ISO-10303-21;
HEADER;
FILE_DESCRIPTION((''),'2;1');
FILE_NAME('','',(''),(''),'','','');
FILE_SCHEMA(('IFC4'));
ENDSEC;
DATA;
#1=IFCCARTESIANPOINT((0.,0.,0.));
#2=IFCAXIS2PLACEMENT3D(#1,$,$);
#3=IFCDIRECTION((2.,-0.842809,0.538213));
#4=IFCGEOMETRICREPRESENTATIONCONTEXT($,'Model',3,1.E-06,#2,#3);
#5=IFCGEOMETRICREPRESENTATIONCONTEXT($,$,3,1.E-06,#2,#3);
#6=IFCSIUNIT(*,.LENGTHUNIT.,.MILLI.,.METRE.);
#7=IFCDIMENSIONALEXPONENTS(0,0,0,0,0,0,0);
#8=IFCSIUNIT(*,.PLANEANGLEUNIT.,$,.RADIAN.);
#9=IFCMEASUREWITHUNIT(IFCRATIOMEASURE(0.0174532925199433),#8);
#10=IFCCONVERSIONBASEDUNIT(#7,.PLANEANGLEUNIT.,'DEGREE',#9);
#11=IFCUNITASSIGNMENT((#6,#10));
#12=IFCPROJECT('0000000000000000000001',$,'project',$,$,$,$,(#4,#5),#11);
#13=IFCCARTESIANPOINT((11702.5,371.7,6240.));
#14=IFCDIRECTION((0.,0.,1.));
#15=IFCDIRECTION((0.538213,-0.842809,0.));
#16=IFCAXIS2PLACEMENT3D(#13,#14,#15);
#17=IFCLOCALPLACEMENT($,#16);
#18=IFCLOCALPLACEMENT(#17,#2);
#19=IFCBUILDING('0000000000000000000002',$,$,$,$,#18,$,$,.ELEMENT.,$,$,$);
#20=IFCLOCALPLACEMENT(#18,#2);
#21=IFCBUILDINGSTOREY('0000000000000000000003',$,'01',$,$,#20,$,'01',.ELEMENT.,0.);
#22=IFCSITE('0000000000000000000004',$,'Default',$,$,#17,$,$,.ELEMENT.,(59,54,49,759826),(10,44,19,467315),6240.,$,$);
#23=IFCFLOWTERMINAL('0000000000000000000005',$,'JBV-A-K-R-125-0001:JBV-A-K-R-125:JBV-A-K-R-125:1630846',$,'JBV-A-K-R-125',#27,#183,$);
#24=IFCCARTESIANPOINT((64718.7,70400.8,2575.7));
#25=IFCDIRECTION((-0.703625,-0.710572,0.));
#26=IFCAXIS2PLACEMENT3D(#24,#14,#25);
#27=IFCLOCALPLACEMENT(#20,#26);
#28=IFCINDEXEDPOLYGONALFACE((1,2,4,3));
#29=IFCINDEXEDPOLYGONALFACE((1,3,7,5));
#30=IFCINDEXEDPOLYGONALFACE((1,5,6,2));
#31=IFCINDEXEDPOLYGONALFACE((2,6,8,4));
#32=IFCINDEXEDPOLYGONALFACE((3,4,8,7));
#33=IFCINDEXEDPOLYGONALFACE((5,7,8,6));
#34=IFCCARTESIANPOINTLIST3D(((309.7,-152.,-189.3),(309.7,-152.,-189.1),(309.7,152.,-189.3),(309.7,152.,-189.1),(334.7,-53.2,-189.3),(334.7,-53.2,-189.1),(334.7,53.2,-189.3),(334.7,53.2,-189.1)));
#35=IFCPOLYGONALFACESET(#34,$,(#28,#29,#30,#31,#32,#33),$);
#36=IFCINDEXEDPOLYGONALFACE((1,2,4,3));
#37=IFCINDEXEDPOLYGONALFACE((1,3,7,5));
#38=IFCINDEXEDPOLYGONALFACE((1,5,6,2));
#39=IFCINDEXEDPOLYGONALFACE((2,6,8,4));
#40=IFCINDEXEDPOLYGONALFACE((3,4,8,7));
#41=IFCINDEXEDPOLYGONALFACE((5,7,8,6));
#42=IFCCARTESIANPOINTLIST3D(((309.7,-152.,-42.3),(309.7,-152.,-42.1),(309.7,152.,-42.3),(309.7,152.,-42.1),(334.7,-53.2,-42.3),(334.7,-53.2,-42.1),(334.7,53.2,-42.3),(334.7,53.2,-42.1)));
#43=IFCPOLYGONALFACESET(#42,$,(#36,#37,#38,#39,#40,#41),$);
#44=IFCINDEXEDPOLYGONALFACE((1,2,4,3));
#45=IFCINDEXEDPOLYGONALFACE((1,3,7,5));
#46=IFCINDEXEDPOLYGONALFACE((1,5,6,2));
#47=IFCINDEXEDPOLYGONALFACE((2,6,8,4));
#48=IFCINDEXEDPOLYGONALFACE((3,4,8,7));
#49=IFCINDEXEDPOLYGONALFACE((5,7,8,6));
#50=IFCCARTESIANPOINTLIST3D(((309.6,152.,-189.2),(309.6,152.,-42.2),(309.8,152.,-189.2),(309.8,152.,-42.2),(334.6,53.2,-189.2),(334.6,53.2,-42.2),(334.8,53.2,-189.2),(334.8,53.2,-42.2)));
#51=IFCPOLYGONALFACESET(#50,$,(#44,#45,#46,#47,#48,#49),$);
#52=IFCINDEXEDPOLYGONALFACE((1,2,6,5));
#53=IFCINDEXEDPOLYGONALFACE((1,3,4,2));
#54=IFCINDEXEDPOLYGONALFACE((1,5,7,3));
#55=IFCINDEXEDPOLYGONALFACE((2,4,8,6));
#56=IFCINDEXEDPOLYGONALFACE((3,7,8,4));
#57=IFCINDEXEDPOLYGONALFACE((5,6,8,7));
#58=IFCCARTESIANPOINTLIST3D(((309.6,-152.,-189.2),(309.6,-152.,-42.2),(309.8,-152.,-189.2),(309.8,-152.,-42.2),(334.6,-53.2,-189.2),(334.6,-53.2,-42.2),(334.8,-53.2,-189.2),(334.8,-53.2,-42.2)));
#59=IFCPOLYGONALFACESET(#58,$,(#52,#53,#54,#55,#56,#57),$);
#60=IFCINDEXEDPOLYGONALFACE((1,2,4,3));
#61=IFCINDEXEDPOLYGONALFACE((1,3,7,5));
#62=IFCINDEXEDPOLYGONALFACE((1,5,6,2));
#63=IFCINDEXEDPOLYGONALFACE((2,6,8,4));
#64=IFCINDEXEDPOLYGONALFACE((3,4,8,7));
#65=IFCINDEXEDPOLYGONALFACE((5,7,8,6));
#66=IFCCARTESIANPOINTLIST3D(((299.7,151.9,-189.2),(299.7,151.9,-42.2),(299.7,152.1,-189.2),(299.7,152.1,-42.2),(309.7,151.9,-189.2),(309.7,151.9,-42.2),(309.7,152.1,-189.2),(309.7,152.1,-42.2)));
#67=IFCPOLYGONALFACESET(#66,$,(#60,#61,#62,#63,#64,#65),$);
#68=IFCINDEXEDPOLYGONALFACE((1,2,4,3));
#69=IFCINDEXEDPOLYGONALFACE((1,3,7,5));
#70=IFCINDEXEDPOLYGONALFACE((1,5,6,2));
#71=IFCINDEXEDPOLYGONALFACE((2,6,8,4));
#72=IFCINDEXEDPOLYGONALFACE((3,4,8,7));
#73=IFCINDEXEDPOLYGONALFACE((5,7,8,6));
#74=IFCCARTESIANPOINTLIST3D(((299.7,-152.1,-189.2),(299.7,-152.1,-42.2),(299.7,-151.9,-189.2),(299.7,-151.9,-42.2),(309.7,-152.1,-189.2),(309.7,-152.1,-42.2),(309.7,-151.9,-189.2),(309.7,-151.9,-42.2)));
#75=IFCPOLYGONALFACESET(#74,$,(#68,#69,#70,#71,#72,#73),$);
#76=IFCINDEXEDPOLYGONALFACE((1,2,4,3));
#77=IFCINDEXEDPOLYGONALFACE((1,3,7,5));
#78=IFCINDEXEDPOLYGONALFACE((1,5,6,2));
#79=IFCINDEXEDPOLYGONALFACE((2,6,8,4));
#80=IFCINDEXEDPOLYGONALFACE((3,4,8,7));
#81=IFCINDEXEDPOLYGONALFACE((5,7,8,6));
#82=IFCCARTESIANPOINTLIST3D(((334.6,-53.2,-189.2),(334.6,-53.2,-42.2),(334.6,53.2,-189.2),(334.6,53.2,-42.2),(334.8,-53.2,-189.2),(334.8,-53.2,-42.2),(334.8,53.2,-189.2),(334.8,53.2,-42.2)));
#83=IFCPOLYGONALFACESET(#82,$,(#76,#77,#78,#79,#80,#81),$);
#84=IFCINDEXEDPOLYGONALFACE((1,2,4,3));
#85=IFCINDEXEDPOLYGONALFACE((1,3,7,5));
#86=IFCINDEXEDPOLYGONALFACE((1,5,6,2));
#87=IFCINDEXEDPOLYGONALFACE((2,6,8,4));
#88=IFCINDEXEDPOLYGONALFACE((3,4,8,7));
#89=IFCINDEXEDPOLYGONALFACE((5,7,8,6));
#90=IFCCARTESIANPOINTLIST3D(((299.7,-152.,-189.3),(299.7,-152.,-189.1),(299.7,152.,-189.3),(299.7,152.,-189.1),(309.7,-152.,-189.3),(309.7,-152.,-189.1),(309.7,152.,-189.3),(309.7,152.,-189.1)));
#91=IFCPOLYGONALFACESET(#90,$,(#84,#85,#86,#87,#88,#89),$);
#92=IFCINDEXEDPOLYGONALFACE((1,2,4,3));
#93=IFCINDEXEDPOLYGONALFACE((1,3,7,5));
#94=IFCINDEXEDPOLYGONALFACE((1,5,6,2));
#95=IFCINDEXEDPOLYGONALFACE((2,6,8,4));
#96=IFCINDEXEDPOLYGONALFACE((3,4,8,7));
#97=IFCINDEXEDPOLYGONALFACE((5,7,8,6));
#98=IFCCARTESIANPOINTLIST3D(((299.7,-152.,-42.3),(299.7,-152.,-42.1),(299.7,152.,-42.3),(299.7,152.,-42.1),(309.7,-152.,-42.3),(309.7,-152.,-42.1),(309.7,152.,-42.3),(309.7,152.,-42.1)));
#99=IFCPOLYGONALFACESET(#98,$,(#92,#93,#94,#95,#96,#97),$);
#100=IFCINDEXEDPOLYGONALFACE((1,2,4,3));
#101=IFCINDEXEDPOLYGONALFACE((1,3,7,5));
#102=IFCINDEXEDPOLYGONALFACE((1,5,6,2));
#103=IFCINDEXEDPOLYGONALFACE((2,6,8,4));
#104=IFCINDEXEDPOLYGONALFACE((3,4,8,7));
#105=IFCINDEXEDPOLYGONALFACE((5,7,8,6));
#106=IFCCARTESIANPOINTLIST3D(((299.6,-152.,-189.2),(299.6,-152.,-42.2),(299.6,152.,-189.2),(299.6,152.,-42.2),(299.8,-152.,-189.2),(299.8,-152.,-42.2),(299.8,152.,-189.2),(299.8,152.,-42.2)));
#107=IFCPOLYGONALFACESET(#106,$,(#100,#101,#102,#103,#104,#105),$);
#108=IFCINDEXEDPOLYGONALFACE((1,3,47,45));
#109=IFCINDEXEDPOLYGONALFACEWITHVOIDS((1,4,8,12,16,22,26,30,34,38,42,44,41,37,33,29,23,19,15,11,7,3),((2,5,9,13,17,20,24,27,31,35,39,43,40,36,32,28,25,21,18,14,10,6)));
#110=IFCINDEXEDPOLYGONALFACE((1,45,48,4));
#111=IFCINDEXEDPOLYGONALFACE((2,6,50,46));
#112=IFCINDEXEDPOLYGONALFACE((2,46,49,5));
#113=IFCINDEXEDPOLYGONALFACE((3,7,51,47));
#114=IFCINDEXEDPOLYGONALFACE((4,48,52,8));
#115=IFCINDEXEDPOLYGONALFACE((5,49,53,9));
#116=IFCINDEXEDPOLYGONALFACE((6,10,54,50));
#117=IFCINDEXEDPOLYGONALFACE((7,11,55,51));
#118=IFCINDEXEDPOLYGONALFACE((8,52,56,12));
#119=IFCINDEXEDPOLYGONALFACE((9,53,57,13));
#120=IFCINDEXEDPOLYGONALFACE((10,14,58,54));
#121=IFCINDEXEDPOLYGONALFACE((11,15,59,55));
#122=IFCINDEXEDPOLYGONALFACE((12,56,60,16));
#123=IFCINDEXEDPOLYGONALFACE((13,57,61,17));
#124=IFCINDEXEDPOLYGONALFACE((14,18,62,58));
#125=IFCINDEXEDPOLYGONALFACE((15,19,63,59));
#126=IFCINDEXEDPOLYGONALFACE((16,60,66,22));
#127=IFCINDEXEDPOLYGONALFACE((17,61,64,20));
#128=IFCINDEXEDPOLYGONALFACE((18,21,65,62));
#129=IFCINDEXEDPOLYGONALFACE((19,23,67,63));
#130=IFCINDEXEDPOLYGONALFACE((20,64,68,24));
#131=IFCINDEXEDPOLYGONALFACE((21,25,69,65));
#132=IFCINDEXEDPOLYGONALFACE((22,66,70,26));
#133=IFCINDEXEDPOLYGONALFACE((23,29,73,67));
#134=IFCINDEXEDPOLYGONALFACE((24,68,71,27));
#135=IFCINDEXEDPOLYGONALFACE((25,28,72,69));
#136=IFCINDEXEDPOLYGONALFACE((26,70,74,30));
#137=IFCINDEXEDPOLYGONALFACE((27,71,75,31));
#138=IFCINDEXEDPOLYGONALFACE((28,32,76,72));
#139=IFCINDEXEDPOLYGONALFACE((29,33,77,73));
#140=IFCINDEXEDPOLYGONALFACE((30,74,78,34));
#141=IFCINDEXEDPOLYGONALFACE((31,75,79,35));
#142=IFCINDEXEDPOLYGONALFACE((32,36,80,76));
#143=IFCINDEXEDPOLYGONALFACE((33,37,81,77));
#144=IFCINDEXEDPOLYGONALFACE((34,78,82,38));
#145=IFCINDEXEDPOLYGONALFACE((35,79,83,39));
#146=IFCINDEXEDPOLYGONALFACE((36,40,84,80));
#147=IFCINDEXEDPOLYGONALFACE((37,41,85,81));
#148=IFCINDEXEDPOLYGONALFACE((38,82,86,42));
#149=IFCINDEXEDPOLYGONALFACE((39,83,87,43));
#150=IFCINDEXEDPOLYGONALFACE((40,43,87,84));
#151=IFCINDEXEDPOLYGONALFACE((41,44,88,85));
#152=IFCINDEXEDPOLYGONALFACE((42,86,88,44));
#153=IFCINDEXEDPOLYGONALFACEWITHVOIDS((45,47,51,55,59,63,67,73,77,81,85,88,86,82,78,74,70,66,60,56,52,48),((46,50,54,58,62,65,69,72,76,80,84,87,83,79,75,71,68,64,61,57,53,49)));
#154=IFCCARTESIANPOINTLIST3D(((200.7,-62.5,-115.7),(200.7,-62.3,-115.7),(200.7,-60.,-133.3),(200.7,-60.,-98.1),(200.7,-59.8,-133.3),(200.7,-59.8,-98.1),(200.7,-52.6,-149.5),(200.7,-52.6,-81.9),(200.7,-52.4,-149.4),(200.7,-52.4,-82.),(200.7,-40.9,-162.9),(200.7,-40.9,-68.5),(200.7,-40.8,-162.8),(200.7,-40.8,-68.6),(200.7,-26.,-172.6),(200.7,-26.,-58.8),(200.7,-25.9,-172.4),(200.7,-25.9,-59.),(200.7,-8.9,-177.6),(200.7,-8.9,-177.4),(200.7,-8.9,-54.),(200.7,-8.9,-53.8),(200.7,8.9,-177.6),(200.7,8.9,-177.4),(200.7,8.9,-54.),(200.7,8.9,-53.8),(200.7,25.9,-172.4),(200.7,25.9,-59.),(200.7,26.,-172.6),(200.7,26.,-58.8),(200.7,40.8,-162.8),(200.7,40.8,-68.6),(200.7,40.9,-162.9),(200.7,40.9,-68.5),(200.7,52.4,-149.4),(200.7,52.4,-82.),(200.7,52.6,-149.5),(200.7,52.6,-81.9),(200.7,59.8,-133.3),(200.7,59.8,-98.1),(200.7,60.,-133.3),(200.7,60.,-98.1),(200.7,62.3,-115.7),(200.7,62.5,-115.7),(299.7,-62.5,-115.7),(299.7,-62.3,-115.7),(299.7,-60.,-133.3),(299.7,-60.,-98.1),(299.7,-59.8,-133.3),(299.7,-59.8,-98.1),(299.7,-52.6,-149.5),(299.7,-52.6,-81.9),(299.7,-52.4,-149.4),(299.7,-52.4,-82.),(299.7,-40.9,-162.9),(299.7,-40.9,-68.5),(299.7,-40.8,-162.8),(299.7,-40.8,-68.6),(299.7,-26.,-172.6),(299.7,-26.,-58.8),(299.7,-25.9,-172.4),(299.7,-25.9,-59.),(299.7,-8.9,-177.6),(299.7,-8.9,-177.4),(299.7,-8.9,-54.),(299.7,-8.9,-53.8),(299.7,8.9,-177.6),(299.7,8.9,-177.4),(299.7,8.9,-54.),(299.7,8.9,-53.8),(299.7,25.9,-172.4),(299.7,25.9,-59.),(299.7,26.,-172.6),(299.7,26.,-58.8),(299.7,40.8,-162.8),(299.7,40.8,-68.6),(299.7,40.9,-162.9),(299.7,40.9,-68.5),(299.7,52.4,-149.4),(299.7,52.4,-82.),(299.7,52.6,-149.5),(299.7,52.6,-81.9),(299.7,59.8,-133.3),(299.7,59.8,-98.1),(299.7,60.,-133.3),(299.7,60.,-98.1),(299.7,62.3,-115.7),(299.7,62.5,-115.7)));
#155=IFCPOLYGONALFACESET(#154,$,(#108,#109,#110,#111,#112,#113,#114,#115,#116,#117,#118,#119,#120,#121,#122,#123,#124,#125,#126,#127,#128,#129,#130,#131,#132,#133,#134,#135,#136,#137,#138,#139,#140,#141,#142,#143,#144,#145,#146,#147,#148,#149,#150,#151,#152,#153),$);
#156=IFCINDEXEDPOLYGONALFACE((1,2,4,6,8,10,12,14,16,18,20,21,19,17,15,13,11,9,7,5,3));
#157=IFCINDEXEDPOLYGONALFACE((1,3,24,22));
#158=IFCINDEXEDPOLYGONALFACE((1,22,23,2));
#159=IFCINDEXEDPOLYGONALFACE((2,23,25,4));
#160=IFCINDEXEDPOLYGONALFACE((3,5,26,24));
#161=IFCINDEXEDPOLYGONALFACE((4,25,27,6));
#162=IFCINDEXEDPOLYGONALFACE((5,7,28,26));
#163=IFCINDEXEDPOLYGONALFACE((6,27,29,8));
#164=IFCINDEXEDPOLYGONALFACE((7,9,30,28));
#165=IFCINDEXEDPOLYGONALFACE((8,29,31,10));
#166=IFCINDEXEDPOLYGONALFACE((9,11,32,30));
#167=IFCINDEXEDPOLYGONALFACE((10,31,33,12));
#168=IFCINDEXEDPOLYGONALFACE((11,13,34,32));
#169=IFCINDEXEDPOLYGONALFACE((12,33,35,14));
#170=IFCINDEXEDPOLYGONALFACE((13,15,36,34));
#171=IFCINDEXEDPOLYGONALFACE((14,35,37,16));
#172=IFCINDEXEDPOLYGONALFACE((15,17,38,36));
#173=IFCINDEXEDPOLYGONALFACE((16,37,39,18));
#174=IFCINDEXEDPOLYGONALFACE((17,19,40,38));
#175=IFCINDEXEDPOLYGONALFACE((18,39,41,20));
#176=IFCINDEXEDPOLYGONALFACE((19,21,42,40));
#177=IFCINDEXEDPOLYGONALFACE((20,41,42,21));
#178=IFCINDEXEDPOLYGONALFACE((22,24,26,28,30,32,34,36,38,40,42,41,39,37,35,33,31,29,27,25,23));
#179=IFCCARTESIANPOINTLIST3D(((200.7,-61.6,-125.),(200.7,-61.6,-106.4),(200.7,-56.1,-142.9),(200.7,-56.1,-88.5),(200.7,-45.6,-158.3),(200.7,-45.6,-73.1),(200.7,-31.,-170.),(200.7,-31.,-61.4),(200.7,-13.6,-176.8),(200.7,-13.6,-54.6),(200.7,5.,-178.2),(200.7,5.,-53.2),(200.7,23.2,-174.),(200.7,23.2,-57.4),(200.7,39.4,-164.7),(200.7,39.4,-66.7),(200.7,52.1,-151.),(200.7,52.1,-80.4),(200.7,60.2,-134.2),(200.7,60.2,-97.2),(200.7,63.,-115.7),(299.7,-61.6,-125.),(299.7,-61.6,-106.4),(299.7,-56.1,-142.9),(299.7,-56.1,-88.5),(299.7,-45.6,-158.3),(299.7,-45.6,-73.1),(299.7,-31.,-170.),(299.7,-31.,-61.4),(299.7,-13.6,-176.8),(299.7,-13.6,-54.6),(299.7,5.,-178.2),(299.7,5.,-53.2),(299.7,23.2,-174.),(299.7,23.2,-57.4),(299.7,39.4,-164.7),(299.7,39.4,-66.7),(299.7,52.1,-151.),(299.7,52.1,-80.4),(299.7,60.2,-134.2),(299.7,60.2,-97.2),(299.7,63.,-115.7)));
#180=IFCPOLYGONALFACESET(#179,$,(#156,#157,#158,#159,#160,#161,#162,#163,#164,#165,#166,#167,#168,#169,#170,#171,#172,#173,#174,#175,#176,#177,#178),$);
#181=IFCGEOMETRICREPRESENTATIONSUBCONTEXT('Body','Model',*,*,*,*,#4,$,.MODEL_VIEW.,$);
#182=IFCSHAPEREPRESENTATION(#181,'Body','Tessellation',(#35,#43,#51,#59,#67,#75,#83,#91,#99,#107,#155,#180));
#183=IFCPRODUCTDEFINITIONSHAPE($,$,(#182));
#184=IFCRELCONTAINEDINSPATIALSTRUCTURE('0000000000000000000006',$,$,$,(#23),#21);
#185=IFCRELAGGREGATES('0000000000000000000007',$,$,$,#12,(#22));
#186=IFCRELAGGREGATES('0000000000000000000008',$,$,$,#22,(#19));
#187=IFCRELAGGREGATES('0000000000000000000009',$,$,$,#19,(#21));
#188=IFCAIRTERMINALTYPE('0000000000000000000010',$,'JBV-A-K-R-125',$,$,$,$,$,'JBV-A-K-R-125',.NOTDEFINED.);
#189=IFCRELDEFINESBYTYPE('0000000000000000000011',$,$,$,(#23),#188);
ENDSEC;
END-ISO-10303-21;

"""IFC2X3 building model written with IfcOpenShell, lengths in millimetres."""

from ifc_helpers import new_model, entity, si_unit, converted_unit, direction, frame, frame_2d, origin, origin_2d_with_axis, place, context, subcontext, project, spatial, polyline, circle_curve, parameter, trimmed, segment, composite_curve, rectangle, circle, outline, extrude, source, transform, mapped, type_object, type_shapes, element, save


model = new_model("IFC2X3")

# Units and contexts
model_context = context("Model", 3, precision=1e-06, world=origin(), true_north=direction((2.0, -0.842809, 0.538213)))
context_of_model = context(None, 3, precision=1e-06, world=origin(), true_north=direction((2.0, -0.842809, 0.538213)))
body_context = subcontext(model_context, "Body", "Model", "MODEL_VIEW")
ifc_project = project(units=[si_unit("LENGTHUNIT", "METRE", prefix="MILLI"), converted_unit("PLANEANGLEUNIT", "DEGREE", entity("IfcRatioMeasure", 0.0174532925199433), si_unit("PLANEANGLEUNIT", "RADIAN"), dimensions=[0, 0, 0, 0, 0, 0, 0])], contexts=[model_context, context_of_model])

# Site, building, storey
site_placement = place(None, frame((11702.5, 371.7, 6240.0), z_axis=(0.0, 0.0, 1.0), x_axis=(0.538213, -0.842809, 0.0)))
site = spatial("IfcSite", under=ifc_project, at=site_placement, Name="Default", CompositionType="ELEMENT", RefLatitude=(59, 54, 49, 759826), RefLongitude=(10, 44, 19, 467315), RefElevation=6240.0)
building_placement = place(site_placement, origin())
building = spatial("IfcBuilding", under=site, at=building_placement, CompositionType="ELEMENT")
storey_placement = place(building_placement, origin())
storey = spatial("IfcBuildingStorey", under=building, at=storey_placement, Name="01", LongName="01", CompositionType="ELEMENT", Elevation=0.0)

# Flow terminal
air_terminal_type_1 = type_object("IfcAirTerminalType", Name="JBV-A-K-R-125", ElementType="JBV-A-K-R-125", PredefinedType="NOTDEFINED")
shared_shape_1 = source(origin(), body_context, "Body", "SweptSolid", [
    extrude(outline(polyline([(-152.0, -12.5), (152.0, -12.5), (53.2, 12.5), (-53.2, 12.5), (-152.0, -12.5)])), frame((322.2, 0.0, -189.3), z_axis=(0.0, 0.0, 1.0), x_axis=(0.0, -1.0, 0.0)), (0.0, 0.0, 1.0), 0.2),
    extrude(outline(polyline([(-152.0, -12.5), (152.0, -12.5), (53.2, 12.5), (-53.2, 12.5), (-152.0, -12.5)])), frame((322.2, 0.0, -42.3), z_axis=(0.0, 0.0, 1.0), x_axis=(0.0, -1.0, 0.0)), (0.0, 0.0, 1.0), 0.2),
    extrude(rectangle(XDim=0.2, YDim=101.9, at=frame_2d((0.0, 0.0), x_axis=(1.0, 0.0))), frame((322.2, 102.6, -189.2), z_axis=(0.0, 0.0, 1.0), x_axis=(0.969446, 0.245305, 0.0)), (0.0, 0.0, 1.0), 147.0),
    extrude(rectangle(XDim=0.2, YDim=101.9, at=frame_2d((0.0, 0.0), x_axis=(1.0, 0.0))), frame((322.2, -102.6, -189.2), z_axis=(0.0, 0.0, 1.0), x_axis=(-0.969446, 0.245305, 0.0)), (0.0, 0.0, 1.0), 147.0),
    extrude(rectangle(XDim=0.2, YDim=10.0, at=frame_2d((0.0, 0.0), x_axis=(1.0, 0.0))), frame((304.7, 152.0, -189.2), z_axis=(0.0, 0.0, 1.0), x_axis=(0.0, 1.0, 0.0)), (0.0, 0.0, 1.0), 147.0),
    extrude(rectangle(XDim=0.2, YDim=10.0, at=frame_2d((0.0, 0.0), x_axis=(1.0, 0.0))), frame((304.7, -152.0, -189.2), z_axis=(0.0, 0.0, 1.0), x_axis=(0.0, 1.0, 0.0)), (0.0, 0.0, 1.0), 147.0),
    extrude(rectangle(XDim=0.2, YDim=106.4, at=frame_2d((0.0, 0.0), x_axis=(1.0, 0.0))), frame((334.7, 0.0, -189.2)), (0.0, 0.0, 1.0), 147.0),
    extrude(rectangle(XDim=304.0, YDim=10.0, at=frame_2d((0.0, 0.0), x_axis=(1.0, 0.0))), frame((304.7, 0.0, -189.3), z_axis=(0.0, 0.0, 1.0), x_axis=(0.0, -1.0, 0.0)), (0.0, 0.0, 1.0), 0.2),
    extrude(rectangle(XDim=304.0, YDim=10.0, at=frame_2d((0.0, 0.0), x_axis=(1.0, 0.0))), frame((304.7, 0.0, -42.3), z_axis=(0.0, 0.0, 1.0), x_axis=(0.0, -1.0, 0.0)), (0.0, 0.0, 1.0), 0.2),
    extrude(rectangle(XDim=0.2, YDim=304.0, at=frame_2d((0.0, 0.0), x_axis=(1.0, 0.0))), frame((299.7, 0.0, -189.2)), (0.0, 0.0, 1.0), 147.0),
    extrude(outline(composite_curve([segment(trimmed(circle_curve(origin_2d_with_axis(), 62.5), [parameter(0.0)], [parameter(180.0)], True, "PARAMETER"), True, "CONTINUOUS"), segment(trimmed(circle_curve(origin_2d_with_axis(), 62.5), [parameter(180.0)], [parameter(360.0)], True, "PARAMETER"), True, "CONTINUOUS")], self_intersect=False), holes=[composite_curve([segment(trimmed(circle_curve(origin_2d_with_axis(), 62.3), [parameter(180.0)], [parameter(360.0)], True, "PARAMETER"), False, "CONTINUOUS"), segment(trimmed(circle_curve(origin_2d_with_axis(), 62.3), [parameter(0.0)], [parameter(180.0)], True, "PARAMETER"), False, "CONTINUOUS")], self_intersect=False)]), frame((200.7, 0.0, -115.7), z_axis=(1.0, 0.0, 0.0), x_axis=(0.0, 1.0, 0.0)), (0.0, 0.0, 1.0), 99.0),
    extrude(circle(Radius=62.6, at=frame_2d((0.0, 0.0), x_axis=(1.0, 0.0))), frame((200.7, 0.3, -115.7), z_axis=(1.0, 0.0, 0.0), x_axis=(0.0, 1.0, 0.0)), (0.0, 0.0, 1.0), 99.0),
])
type_shapes(air_terminal_type_1, [shared_shape_1])
flow_terminal_1_placement = place(storey_placement, frame((64718.7, 70400.8, 2575.7), z_axis=(0.0, 0.0, 1.0), x_axis=(-0.703625, -0.710572, 0.0)))
element("IfcFlowTerminal", 1, at=flow_terminal_1_placement, inside=storey, type_object=air_terminal_type_1, Name="JBV-A-K-R-125-0001:JBV-A-K-R-125:JBV-A-K-R-125:1630846", ObjectType="JBV-A-K-R-125", context=body_context, shape_type="MappedRepresentation", body=[
    mapped(shared_shape_1, transform((0.0, 0.0, 0.0), scale=1.0)),
])

save(model, "model.ifc")
